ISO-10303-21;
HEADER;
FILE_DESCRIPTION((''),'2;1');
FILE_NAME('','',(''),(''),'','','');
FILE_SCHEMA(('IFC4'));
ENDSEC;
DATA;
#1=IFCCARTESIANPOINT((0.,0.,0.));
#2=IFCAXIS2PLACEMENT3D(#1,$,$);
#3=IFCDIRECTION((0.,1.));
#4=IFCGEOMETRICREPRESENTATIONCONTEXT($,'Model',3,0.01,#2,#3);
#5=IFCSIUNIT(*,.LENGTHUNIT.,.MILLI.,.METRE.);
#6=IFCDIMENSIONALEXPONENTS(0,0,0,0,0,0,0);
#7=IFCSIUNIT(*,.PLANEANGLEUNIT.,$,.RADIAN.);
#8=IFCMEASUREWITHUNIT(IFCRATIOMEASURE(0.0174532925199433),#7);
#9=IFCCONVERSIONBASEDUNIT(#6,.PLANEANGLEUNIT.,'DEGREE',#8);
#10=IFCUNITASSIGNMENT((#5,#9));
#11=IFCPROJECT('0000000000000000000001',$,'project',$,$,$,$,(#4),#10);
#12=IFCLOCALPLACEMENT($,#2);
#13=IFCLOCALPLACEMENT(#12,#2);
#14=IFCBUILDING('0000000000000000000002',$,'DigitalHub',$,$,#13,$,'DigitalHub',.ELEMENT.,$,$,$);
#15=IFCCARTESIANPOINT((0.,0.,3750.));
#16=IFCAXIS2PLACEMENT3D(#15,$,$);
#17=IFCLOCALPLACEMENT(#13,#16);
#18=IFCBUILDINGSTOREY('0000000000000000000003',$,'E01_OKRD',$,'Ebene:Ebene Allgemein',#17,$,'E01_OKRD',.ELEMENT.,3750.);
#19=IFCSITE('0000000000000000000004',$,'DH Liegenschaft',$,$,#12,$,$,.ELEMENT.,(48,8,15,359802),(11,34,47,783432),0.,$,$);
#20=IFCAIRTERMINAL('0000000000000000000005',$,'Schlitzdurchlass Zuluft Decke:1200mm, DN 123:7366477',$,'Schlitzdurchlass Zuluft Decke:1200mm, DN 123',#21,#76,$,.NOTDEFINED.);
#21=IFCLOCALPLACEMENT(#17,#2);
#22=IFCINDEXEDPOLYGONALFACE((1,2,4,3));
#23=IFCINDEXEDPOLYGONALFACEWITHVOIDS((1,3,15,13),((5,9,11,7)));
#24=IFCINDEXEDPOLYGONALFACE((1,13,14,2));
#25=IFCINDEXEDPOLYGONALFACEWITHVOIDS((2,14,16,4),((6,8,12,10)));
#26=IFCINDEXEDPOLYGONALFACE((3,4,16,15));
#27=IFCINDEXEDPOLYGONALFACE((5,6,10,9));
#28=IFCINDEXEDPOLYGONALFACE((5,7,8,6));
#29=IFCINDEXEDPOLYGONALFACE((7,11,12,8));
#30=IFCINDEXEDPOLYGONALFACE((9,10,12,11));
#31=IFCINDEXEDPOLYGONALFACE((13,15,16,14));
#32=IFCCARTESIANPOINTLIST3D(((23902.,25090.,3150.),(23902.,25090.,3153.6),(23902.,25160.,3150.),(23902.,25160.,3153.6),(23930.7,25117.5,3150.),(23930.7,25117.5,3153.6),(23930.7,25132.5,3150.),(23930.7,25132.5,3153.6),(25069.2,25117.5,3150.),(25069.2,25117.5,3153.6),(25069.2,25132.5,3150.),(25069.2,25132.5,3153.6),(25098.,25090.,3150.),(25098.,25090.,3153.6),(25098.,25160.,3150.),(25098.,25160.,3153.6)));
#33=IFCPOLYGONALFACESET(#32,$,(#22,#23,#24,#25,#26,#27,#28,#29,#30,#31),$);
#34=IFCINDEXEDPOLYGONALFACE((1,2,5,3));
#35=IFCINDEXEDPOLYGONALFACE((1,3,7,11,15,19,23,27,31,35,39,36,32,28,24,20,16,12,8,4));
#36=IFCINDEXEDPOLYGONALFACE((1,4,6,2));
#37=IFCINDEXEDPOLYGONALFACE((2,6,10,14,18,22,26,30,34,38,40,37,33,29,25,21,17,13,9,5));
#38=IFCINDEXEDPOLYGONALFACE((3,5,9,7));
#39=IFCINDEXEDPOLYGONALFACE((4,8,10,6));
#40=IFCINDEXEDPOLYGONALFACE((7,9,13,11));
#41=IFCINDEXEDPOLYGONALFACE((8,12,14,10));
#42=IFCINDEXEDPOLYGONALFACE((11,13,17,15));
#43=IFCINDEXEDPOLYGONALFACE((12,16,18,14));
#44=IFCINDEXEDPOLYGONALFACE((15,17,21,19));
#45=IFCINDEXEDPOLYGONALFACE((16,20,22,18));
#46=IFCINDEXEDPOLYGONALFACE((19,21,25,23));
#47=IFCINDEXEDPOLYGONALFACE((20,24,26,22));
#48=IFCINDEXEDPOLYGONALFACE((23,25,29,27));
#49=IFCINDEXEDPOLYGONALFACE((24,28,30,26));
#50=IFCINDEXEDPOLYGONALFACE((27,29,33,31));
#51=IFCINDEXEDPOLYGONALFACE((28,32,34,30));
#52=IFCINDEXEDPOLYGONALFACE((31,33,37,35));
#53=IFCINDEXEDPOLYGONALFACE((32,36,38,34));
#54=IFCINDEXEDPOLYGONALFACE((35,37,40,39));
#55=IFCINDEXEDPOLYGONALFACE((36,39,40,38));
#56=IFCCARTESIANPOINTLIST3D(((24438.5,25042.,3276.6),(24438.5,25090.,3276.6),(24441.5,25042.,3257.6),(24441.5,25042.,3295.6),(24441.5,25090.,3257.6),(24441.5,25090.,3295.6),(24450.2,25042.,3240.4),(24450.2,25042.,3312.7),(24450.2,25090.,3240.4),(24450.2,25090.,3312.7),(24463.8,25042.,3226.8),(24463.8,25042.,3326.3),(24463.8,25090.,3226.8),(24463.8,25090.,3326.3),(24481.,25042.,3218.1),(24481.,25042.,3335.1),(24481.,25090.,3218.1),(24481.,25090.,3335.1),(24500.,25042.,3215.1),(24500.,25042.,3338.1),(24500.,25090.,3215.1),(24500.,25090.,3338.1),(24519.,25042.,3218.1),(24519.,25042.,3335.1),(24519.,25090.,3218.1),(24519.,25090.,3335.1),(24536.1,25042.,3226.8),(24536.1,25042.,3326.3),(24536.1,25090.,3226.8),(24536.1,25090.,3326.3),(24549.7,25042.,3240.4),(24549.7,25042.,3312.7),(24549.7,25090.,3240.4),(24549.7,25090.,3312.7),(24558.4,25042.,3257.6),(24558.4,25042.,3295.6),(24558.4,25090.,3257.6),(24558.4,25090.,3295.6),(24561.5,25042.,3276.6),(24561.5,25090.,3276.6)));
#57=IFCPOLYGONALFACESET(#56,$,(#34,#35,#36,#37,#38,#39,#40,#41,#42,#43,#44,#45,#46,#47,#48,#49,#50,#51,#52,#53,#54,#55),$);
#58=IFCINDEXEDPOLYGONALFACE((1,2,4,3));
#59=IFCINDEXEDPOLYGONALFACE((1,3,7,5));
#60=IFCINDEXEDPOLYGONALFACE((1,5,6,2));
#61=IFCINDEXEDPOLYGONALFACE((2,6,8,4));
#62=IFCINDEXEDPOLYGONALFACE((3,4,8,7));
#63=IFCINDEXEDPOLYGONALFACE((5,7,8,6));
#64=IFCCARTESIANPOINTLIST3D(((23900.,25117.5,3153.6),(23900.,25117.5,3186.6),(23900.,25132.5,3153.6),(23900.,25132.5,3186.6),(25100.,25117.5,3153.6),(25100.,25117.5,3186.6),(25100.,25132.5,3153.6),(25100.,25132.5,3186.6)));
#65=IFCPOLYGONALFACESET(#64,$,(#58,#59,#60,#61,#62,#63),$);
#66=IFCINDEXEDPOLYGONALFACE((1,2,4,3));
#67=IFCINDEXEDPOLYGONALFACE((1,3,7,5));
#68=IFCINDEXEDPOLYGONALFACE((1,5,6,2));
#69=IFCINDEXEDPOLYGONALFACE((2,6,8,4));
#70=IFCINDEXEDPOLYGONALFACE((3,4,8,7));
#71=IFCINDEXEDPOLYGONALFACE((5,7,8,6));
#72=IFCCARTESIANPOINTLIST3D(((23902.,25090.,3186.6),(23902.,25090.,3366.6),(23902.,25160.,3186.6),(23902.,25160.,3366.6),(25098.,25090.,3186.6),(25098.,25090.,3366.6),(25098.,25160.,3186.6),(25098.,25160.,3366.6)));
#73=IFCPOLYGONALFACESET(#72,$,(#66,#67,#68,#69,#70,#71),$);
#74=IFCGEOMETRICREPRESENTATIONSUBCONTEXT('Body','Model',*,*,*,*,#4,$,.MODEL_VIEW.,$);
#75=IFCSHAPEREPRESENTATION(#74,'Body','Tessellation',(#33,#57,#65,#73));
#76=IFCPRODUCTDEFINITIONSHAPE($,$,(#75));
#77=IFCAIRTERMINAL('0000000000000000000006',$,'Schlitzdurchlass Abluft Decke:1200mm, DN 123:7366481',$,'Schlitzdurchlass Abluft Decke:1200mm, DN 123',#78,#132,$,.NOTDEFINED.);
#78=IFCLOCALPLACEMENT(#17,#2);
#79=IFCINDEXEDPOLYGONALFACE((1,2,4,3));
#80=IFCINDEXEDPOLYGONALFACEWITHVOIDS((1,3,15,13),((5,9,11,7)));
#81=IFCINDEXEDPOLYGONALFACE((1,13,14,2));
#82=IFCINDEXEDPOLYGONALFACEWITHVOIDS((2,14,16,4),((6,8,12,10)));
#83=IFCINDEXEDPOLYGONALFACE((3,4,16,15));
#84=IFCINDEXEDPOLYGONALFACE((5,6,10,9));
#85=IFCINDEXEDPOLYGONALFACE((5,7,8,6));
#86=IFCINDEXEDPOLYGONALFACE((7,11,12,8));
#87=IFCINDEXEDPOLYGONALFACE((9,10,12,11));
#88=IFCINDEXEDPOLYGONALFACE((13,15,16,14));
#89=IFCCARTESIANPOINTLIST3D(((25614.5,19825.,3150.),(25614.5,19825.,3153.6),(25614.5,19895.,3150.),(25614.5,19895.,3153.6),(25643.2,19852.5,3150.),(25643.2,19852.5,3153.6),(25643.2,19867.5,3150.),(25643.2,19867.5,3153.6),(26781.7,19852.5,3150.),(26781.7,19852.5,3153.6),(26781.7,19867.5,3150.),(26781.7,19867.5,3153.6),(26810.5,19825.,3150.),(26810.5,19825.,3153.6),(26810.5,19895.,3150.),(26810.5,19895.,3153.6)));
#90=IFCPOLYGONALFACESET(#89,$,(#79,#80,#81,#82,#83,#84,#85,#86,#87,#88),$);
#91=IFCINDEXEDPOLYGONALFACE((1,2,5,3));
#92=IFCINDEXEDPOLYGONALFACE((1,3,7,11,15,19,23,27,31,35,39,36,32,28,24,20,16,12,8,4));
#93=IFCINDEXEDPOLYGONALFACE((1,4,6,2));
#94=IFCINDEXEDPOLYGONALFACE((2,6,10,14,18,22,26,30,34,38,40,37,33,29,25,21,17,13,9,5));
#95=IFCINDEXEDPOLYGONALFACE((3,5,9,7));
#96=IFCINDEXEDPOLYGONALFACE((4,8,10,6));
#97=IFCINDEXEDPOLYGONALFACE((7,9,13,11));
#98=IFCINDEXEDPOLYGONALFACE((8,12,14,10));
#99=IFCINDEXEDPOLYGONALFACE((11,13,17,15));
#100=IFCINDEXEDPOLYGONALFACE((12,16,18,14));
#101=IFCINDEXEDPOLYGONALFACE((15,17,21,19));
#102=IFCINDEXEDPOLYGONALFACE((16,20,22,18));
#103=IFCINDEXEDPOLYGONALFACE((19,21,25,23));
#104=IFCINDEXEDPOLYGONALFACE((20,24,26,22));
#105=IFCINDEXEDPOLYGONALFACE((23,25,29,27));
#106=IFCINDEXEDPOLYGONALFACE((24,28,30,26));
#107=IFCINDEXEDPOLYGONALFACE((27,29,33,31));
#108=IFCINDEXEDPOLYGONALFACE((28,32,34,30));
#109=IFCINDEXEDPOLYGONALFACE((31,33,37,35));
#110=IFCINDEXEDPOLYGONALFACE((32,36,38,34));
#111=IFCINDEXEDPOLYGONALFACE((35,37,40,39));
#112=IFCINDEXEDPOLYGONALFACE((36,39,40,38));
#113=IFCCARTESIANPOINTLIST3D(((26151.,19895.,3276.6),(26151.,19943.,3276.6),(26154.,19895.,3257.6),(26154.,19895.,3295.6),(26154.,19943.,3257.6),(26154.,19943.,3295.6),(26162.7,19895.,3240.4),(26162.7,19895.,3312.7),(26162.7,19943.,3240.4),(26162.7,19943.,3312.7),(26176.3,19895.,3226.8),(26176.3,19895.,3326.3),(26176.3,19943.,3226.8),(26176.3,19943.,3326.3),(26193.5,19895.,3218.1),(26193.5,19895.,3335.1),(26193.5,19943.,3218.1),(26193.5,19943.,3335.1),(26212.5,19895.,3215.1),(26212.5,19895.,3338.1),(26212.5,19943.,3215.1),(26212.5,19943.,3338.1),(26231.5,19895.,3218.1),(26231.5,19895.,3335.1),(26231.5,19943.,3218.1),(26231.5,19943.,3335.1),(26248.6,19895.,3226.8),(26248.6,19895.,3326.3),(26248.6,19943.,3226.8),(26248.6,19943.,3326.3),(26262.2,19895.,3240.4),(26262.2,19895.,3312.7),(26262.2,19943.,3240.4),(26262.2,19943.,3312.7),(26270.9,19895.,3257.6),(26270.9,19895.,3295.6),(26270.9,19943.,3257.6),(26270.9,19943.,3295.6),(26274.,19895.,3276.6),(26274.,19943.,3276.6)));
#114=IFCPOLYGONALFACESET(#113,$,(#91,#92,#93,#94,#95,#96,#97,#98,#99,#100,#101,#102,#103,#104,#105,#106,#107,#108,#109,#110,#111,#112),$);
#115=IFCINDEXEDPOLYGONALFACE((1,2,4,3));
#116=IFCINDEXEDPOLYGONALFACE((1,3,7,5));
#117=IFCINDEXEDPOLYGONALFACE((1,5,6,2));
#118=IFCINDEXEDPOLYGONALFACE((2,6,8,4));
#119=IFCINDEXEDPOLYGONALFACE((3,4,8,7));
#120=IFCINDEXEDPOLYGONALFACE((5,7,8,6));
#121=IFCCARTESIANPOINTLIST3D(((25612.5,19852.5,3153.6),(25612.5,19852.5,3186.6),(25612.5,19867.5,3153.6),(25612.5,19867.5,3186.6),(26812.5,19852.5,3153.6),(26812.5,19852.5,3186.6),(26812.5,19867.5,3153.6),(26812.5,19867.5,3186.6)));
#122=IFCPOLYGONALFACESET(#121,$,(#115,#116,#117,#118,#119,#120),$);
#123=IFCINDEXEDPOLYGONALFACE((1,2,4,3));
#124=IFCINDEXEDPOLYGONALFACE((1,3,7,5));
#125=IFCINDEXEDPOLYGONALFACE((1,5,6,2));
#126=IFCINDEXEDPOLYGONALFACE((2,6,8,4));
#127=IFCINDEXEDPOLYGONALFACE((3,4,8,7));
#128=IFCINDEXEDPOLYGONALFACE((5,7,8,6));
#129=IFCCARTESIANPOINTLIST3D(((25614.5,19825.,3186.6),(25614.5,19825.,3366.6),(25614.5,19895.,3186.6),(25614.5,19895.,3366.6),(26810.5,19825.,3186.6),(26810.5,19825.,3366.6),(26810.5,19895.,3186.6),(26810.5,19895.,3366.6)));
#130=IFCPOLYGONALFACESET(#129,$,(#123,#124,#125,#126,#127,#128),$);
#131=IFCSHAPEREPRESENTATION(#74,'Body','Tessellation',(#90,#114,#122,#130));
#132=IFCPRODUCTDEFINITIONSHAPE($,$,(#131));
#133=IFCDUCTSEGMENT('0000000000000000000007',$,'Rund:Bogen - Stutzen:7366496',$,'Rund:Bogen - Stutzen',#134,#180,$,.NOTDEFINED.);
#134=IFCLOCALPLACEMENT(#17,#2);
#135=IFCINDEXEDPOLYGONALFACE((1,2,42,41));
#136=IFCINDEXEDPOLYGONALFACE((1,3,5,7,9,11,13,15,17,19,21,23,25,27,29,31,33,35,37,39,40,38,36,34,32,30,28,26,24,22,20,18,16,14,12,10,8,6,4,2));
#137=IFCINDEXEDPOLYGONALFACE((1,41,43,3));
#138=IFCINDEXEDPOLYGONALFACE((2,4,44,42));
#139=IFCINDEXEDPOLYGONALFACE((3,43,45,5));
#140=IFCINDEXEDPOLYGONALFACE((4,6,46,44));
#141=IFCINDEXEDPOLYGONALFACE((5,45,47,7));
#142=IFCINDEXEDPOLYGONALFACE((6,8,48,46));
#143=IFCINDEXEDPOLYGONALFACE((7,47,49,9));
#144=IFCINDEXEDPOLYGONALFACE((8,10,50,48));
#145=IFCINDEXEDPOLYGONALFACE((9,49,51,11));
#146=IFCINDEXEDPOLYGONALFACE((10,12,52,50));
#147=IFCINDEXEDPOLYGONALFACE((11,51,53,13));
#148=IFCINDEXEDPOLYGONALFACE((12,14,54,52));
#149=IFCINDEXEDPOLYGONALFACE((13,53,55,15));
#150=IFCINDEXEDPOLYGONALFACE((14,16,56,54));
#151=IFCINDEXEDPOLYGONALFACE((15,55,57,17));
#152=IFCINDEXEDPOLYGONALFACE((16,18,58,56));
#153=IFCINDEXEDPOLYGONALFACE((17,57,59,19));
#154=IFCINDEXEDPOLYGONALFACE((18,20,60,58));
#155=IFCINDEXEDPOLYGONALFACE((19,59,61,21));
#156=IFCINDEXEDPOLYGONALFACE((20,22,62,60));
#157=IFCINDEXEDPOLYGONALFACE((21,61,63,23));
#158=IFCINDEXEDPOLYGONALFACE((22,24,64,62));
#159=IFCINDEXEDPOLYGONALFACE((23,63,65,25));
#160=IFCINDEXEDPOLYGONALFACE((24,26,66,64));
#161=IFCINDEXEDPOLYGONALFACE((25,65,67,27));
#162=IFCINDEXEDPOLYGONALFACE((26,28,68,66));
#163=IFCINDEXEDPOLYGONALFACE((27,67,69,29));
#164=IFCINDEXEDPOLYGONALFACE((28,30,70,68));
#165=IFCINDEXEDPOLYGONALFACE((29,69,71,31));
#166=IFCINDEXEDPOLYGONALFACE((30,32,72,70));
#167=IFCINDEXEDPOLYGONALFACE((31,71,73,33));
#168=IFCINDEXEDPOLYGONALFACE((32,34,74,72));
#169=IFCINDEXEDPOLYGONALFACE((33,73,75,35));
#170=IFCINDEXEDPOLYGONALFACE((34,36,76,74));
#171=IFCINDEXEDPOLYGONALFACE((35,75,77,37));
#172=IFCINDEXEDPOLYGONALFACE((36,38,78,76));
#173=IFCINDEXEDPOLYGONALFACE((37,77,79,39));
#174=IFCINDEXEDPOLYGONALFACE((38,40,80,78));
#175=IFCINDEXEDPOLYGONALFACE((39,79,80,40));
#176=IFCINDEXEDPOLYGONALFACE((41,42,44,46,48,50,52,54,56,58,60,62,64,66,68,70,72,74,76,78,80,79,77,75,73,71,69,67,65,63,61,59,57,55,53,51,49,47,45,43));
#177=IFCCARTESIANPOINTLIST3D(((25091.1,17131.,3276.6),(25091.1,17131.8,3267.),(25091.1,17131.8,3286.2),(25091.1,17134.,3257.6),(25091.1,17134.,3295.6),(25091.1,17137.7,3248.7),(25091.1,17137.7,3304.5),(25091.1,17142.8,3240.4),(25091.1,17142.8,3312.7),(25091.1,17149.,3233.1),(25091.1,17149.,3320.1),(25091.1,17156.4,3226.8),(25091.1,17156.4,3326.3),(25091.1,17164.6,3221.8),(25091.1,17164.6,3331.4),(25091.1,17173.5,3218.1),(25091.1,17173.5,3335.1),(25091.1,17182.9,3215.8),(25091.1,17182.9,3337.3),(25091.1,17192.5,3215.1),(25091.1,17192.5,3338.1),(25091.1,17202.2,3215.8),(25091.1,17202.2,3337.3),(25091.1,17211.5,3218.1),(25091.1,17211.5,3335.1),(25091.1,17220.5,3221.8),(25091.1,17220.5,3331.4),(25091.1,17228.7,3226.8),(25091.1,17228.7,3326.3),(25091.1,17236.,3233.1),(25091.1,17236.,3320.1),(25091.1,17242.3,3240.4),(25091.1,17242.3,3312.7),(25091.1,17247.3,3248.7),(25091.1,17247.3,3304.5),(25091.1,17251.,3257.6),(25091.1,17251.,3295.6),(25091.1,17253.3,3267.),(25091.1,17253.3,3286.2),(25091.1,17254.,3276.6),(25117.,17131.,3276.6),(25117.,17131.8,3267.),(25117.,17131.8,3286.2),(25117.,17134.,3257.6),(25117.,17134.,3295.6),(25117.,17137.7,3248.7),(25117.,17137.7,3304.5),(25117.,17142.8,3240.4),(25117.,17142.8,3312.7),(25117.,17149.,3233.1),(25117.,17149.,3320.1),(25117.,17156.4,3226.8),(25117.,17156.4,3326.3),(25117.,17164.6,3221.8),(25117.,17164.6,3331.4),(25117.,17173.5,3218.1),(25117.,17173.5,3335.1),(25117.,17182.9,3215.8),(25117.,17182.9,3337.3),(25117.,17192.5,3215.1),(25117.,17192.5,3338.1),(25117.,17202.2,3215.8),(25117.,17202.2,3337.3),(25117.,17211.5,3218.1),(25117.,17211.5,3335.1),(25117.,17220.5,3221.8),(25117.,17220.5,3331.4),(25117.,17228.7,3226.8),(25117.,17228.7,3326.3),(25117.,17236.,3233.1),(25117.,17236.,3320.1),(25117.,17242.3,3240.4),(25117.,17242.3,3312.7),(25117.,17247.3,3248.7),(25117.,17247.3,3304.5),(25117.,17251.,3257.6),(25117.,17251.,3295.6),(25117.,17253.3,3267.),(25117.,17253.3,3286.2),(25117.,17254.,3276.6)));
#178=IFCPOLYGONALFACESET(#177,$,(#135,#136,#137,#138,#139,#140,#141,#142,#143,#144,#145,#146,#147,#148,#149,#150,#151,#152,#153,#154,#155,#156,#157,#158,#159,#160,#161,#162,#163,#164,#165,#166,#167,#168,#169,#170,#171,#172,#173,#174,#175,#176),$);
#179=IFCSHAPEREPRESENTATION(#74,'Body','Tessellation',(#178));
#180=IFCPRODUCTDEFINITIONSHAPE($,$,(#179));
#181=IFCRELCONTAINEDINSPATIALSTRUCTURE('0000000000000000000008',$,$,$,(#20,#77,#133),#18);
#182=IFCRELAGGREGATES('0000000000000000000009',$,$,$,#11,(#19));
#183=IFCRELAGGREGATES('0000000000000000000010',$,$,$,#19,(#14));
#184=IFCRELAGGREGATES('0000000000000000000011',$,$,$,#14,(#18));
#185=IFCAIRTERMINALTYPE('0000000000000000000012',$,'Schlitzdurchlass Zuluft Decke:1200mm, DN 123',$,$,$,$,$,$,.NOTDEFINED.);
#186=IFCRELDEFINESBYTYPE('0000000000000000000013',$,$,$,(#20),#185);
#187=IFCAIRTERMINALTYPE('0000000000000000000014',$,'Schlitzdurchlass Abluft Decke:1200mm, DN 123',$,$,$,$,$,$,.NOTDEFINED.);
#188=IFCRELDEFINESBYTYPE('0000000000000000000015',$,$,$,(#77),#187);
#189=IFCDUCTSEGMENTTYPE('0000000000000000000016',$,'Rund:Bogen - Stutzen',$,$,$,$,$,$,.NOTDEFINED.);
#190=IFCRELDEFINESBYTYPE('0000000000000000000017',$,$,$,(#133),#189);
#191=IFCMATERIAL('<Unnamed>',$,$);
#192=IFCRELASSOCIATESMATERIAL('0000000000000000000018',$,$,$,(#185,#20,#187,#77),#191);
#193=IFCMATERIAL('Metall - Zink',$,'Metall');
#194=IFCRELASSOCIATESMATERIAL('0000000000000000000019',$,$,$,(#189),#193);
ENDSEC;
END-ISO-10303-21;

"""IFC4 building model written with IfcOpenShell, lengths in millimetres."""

from ifc_helpers import new_model, entity, si_unit, converted_unit, direction, frame, origin, place, context, subcontext, project, spatial, indexed_curve, outline, extrude, source, transform, mapped, material, type_object, type_shapes, element, save


model = new_model("IFC4")

# Units and contexts
model_context = context("Model", 3, precision=0.01, world=origin(), true_north=direction((0.0, 1.0)))
body_context = subcontext(model_context, "Body", "Model", "MODEL_VIEW")
ifc_project = project(units=[si_unit("LENGTHUNIT", "METRE", prefix="MILLI"), converted_unit("PLANEANGLEUNIT", "DEGREE", entity("IfcRatioMeasure", 0.0174532925199433), si_unit("PLANEANGLEUNIT", "RADIAN"), dimensions=[0, 0, 0, 0, 0, 0, 0])], contexts=[model_context])

# Site, building, storey
site_placement = place(None, origin())
site = spatial("IfcSite", under=ifc_project, at=site_placement, Name="DH Liegenschaft", CompositionType="ELEMENT", RefLatitude=(48, 8, 15, 359802), RefLongitude=(11, 34, 47, 783432), RefElevation=0.0)
building_placement = place(site_placement, origin())
building = spatial("IfcBuilding", under=site, at=building_placement, Name="DigitalHub", LongName="DigitalHub", CompositionType="ELEMENT")
storey_placement = place(building_placement, frame((0.0, 0.0, 3750.0)))
storey = spatial("IfcBuildingStorey", under=building, at=storey_placement, Name="E01_OKRD", ObjectType="Ebene:Ebene Allgemein", LongName="E01_OKRD", CompositionType="ELEMENT", Elevation=3750.0)

# Shared definitions
ifc_material_1 = material(Name="Metall - Zink", Category="Metall")

# Air terminals
ifc_material_2 = material(Name="<Unnamed>")
air_terminal_type_1 = type_object("IfcAirTerminalType", Name="Schlitzdurchlass Zuluft Decke:1200mm, DN 123", PredefinedType="NOTDEFINED", material=ifc_material_2)
shared_shape_1 = source(origin(), body_context, "Body", "SweptSolid", [
    extrude(outline(indexed_curve([(-598.0, -35.0), (598.0, -35.0), (598.0, 35.0), (-598.0, 35.0), (-598.0, -35.0)], self_intersect=False), holes=[indexed_curve([(-569.2, -7.5), (-569.2, 7.5), (569.2, 7.5), (569.2, -7.5), (-569.2, -7.5)], self_intersect=False)]), frame((600.0, 35.0, 0.0), z_axis=(0.0, 0.0, 1.0), x_axis=(-1.0, 0.0, 0.0)), (0.0, 0.0, 1.0), 3.6),
    extrude(outline(indexed_curve([(61.5, 0.0), (58.5, 19.0), (49.8, 36.1), (36.1, 49.8), (19.0, 58.5), (0.0, 61.5), (-19.0, 58.5), (-36.1, 49.8), (-49.8, 36.1), (-58.5, 19.0), (-61.5, 0.0), (-58.5, -19.0), (-49.8, -36.1), (-36.1, -49.8), (-19.0, -58.5), (0.0, -61.5), (19.0, -58.5), (36.1, -49.8), (49.8, -36.1), (58.5, -19.0), (61.5, 0.0)], self_intersect=False)), frame((600.0, 70.0, 126.6), z_axis=(0.0, 1.0, 0.0), x_axis=(-1.0, 0.0, 0.0)), (0.0, 0.0, 1.0), 48.0),
    extrude(outline(indexed_curve([(-600.0, -7.5), (600.0, -7.5), (600.0, 7.5), (-600.0, 7.5), (-600.0, -7.5)], self_intersect=False)), frame((600.0, 35.0, 3.6), z_axis=(0.0, 0.0, 1.0), x_axis=(-1.0, 0.0, 0.0)), (0.0, 0.0, 1.0), 33.0),
    extrude(outline(indexed_curve([(-598.0, -35.0), (598.0, -35.0), (598.0, 35.0), (-598.0, 35.0), (-598.0, -35.0)], self_intersect=False)), frame((600.0, 35.0, 36.6), z_axis=(0.0, 0.0, 1.0), x_axis=(-1.0, 0.0, 0.0)), (0.0, 0.0, 1.0), 180.0),
])
type_shapes(air_terminal_type_1, [shared_shape_1])
air_terminal_1_placement = place(storey_placement, frame((25100.0, 25160.0, 3150.0), z_axis=(0.0, 0.0, 1.0), x_axis=(-1.0, 0.0, 0.0)))
element("IfcAirTerminal", 1, at=air_terminal_1_placement, inside=storey, type_object=air_terminal_type_1, material=ifc_material_2, Name="Schlitzdurchlass Zuluft Decke:1200mm, DN 123:7366477", ObjectType="Schlitzdurchlass Zuluft Decke:1200mm, DN 123", PredefinedType="NOTDEFINED", context=body_context, shape_type="MappedRepresentation", body=[
    mapped(shared_shape_1, transform((0.0, 0.0, 0.0), scale=1.0)),
])
air_terminal_type_2 = type_object("IfcAirTerminalType", Name="Schlitzdurchlass Abluft Decke:1200mm, DN 123", PredefinedType="NOTDEFINED", material=ifc_material_2)
shared_shape_2 = source(origin(), body_context, "Body", "SweptSolid", [
    extrude(outline(indexed_curve([(-598.0, -35.0), (598.0, -35.0), (598.0, 35.0), (-598.0, 35.0), (-598.0, -35.0)], self_intersect=False), holes=[indexed_curve([(-569.2, -7.5), (-569.2, 7.5), (569.2, 7.5), (569.2, -7.5), (-569.2, -7.5)], self_intersect=False)]), frame((0.0, 0.0, 0.0), z_axis=(0.0, 0.0, 1.0), x_axis=(-1.0, 0.0, 0.0)), (0.0, 0.0, 1.0), 3.6),
    extrude(outline(indexed_curve([(61.5, 0.0), (58.5, 19.0), (49.8, 36.1), (36.1, 49.8), (19.0, 58.5), (0.0, 61.5), (-19.0, 58.5), (-36.1, 49.8), (-49.8, 36.1), (-58.5, 19.0), (-61.5, 0.0), (-58.5, -19.0), (-49.8, -36.1), (-36.1, -49.8), (-19.0, -58.5), (0.0, -61.5), (19.0, -58.5), (36.1, -49.8), (49.8, -36.1), (58.5, -19.0), (61.5, 0.0)], self_intersect=False)), frame((0.0, 35.0, 126.6), z_axis=(0.0, 1.0, 0.0), x_axis=(-1.0, 0.0, 0.0)), (0.0, 0.0, 1.0), 48.0),
    extrude(outline(indexed_curve([(-600.0, -7.5), (600.0, -7.5), (600.0, 7.5), (-600.0, 7.5), (-600.0, -7.5)], self_intersect=False)), frame((0.0, 0.0, 3.6), z_axis=(0.0, 0.0, 1.0), x_axis=(-1.0, 0.0, 0.0)), (0.0, 0.0, 1.0), 33.0),
    extrude(outline(indexed_curve([(-598.0, -35.0), (598.0, -35.0), (598.0, 35.0), (-598.0, 35.0), (-598.0, -35.0)], self_intersect=False)), frame((0.0, 0.0, 36.6), z_axis=(0.0, 0.0, 1.0), x_axis=(-1.0, 0.0, 0.0)), (0.0, 0.0, 1.0), 180.0),
])
type_shapes(air_terminal_type_2, [shared_shape_2])
air_terminal_2_placement = place(storey_placement, frame((26212.5, 19860.0, 3150.0)))
element("IfcAirTerminal", 2, at=air_terminal_2_placement, inside=storey, type_object=air_terminal_type_2, material=ifc_material_2, Name="Schlitzdurchlass Abluft Decke:1200mm, DN 123:7366481", ObjectType="Schlitzdurchlass Abluft Decke:1200mm, DN 123", PredefinedType="NOTDEFINED", context=body_context, shape_type="MappedRepresentation", body=[
    mapped(shared_shape_2, transform((0.0, 0.0, 0.0), scale=1.0)),
])

# Duct segment
duct_segment_type_1 = type_object("IfcDuctSegmentType", Name="Rund:Bogen - Stutzen", PredefinedType="NOTDEFINED", material=ifc_material_1)
duct_segment_1_placement = place(storey_placement, frame((25091.1, 17129.4, 3213.5)))
element("IfcDuctSegment", 3, at=duct_segment_1_placement, inside=storey, type_object=duct_segment_type_1, Name="Rund:Bogen - Stutzen:7366496", ObjectType="Rund:Bogen - Stutzen", PredefinedType="NOTDEFINED", context=body_context, shape_type="SweptSolid", body=[
    extrude(outline(indexed_curve([(61.5, 0.0), (60.7, 9.6), (58.5, 19.0), (54.8, 27.9), (49.8, 36.1), (43.5, 43.5), (36.1, 49.8), (27.9, 54.8), (19.0, 58.5), (9.6, 60.7), (0.0, 61.5), (-9.6, 60.7), (-19.0, 58.5), (-27.9, 54.8), (-36.1, 49.8), (-43.5, 43.5), (-49.8, 36.1), (-54.8, 27.9), (-58.5, 19.0), (-60.7, 9.6), (-61.5, 0.0), (-60.7, -9.6), (-58.5, -19.0), (-54.8, -27.9), (-49.8, -36.1), (-43.5, -43.5), (-36.1, -49.8), (-27.9, -54.8), (-19.0, -58.5), (-9.6, -60.7), (0.0, -61.5), (9.6, -60.7), (19.0, -58.5), (27.9, -54.8), (36.1, -49.8), (43.5, -43.5), (49.8, -36.1), (54.8, -27.9), (58.5, -19.0), (60.7, -9.6), (61.5, 0.0)], self_intersect=False)), frame((0.0, 63.1, 63.1), z_axis=(1.0, 0.0, 0.0), x_axis=(0.0, -1.0, 0.0)), (0.0, 0.0, 1.0), 25.8),
])

save(model, "model.ifc")
